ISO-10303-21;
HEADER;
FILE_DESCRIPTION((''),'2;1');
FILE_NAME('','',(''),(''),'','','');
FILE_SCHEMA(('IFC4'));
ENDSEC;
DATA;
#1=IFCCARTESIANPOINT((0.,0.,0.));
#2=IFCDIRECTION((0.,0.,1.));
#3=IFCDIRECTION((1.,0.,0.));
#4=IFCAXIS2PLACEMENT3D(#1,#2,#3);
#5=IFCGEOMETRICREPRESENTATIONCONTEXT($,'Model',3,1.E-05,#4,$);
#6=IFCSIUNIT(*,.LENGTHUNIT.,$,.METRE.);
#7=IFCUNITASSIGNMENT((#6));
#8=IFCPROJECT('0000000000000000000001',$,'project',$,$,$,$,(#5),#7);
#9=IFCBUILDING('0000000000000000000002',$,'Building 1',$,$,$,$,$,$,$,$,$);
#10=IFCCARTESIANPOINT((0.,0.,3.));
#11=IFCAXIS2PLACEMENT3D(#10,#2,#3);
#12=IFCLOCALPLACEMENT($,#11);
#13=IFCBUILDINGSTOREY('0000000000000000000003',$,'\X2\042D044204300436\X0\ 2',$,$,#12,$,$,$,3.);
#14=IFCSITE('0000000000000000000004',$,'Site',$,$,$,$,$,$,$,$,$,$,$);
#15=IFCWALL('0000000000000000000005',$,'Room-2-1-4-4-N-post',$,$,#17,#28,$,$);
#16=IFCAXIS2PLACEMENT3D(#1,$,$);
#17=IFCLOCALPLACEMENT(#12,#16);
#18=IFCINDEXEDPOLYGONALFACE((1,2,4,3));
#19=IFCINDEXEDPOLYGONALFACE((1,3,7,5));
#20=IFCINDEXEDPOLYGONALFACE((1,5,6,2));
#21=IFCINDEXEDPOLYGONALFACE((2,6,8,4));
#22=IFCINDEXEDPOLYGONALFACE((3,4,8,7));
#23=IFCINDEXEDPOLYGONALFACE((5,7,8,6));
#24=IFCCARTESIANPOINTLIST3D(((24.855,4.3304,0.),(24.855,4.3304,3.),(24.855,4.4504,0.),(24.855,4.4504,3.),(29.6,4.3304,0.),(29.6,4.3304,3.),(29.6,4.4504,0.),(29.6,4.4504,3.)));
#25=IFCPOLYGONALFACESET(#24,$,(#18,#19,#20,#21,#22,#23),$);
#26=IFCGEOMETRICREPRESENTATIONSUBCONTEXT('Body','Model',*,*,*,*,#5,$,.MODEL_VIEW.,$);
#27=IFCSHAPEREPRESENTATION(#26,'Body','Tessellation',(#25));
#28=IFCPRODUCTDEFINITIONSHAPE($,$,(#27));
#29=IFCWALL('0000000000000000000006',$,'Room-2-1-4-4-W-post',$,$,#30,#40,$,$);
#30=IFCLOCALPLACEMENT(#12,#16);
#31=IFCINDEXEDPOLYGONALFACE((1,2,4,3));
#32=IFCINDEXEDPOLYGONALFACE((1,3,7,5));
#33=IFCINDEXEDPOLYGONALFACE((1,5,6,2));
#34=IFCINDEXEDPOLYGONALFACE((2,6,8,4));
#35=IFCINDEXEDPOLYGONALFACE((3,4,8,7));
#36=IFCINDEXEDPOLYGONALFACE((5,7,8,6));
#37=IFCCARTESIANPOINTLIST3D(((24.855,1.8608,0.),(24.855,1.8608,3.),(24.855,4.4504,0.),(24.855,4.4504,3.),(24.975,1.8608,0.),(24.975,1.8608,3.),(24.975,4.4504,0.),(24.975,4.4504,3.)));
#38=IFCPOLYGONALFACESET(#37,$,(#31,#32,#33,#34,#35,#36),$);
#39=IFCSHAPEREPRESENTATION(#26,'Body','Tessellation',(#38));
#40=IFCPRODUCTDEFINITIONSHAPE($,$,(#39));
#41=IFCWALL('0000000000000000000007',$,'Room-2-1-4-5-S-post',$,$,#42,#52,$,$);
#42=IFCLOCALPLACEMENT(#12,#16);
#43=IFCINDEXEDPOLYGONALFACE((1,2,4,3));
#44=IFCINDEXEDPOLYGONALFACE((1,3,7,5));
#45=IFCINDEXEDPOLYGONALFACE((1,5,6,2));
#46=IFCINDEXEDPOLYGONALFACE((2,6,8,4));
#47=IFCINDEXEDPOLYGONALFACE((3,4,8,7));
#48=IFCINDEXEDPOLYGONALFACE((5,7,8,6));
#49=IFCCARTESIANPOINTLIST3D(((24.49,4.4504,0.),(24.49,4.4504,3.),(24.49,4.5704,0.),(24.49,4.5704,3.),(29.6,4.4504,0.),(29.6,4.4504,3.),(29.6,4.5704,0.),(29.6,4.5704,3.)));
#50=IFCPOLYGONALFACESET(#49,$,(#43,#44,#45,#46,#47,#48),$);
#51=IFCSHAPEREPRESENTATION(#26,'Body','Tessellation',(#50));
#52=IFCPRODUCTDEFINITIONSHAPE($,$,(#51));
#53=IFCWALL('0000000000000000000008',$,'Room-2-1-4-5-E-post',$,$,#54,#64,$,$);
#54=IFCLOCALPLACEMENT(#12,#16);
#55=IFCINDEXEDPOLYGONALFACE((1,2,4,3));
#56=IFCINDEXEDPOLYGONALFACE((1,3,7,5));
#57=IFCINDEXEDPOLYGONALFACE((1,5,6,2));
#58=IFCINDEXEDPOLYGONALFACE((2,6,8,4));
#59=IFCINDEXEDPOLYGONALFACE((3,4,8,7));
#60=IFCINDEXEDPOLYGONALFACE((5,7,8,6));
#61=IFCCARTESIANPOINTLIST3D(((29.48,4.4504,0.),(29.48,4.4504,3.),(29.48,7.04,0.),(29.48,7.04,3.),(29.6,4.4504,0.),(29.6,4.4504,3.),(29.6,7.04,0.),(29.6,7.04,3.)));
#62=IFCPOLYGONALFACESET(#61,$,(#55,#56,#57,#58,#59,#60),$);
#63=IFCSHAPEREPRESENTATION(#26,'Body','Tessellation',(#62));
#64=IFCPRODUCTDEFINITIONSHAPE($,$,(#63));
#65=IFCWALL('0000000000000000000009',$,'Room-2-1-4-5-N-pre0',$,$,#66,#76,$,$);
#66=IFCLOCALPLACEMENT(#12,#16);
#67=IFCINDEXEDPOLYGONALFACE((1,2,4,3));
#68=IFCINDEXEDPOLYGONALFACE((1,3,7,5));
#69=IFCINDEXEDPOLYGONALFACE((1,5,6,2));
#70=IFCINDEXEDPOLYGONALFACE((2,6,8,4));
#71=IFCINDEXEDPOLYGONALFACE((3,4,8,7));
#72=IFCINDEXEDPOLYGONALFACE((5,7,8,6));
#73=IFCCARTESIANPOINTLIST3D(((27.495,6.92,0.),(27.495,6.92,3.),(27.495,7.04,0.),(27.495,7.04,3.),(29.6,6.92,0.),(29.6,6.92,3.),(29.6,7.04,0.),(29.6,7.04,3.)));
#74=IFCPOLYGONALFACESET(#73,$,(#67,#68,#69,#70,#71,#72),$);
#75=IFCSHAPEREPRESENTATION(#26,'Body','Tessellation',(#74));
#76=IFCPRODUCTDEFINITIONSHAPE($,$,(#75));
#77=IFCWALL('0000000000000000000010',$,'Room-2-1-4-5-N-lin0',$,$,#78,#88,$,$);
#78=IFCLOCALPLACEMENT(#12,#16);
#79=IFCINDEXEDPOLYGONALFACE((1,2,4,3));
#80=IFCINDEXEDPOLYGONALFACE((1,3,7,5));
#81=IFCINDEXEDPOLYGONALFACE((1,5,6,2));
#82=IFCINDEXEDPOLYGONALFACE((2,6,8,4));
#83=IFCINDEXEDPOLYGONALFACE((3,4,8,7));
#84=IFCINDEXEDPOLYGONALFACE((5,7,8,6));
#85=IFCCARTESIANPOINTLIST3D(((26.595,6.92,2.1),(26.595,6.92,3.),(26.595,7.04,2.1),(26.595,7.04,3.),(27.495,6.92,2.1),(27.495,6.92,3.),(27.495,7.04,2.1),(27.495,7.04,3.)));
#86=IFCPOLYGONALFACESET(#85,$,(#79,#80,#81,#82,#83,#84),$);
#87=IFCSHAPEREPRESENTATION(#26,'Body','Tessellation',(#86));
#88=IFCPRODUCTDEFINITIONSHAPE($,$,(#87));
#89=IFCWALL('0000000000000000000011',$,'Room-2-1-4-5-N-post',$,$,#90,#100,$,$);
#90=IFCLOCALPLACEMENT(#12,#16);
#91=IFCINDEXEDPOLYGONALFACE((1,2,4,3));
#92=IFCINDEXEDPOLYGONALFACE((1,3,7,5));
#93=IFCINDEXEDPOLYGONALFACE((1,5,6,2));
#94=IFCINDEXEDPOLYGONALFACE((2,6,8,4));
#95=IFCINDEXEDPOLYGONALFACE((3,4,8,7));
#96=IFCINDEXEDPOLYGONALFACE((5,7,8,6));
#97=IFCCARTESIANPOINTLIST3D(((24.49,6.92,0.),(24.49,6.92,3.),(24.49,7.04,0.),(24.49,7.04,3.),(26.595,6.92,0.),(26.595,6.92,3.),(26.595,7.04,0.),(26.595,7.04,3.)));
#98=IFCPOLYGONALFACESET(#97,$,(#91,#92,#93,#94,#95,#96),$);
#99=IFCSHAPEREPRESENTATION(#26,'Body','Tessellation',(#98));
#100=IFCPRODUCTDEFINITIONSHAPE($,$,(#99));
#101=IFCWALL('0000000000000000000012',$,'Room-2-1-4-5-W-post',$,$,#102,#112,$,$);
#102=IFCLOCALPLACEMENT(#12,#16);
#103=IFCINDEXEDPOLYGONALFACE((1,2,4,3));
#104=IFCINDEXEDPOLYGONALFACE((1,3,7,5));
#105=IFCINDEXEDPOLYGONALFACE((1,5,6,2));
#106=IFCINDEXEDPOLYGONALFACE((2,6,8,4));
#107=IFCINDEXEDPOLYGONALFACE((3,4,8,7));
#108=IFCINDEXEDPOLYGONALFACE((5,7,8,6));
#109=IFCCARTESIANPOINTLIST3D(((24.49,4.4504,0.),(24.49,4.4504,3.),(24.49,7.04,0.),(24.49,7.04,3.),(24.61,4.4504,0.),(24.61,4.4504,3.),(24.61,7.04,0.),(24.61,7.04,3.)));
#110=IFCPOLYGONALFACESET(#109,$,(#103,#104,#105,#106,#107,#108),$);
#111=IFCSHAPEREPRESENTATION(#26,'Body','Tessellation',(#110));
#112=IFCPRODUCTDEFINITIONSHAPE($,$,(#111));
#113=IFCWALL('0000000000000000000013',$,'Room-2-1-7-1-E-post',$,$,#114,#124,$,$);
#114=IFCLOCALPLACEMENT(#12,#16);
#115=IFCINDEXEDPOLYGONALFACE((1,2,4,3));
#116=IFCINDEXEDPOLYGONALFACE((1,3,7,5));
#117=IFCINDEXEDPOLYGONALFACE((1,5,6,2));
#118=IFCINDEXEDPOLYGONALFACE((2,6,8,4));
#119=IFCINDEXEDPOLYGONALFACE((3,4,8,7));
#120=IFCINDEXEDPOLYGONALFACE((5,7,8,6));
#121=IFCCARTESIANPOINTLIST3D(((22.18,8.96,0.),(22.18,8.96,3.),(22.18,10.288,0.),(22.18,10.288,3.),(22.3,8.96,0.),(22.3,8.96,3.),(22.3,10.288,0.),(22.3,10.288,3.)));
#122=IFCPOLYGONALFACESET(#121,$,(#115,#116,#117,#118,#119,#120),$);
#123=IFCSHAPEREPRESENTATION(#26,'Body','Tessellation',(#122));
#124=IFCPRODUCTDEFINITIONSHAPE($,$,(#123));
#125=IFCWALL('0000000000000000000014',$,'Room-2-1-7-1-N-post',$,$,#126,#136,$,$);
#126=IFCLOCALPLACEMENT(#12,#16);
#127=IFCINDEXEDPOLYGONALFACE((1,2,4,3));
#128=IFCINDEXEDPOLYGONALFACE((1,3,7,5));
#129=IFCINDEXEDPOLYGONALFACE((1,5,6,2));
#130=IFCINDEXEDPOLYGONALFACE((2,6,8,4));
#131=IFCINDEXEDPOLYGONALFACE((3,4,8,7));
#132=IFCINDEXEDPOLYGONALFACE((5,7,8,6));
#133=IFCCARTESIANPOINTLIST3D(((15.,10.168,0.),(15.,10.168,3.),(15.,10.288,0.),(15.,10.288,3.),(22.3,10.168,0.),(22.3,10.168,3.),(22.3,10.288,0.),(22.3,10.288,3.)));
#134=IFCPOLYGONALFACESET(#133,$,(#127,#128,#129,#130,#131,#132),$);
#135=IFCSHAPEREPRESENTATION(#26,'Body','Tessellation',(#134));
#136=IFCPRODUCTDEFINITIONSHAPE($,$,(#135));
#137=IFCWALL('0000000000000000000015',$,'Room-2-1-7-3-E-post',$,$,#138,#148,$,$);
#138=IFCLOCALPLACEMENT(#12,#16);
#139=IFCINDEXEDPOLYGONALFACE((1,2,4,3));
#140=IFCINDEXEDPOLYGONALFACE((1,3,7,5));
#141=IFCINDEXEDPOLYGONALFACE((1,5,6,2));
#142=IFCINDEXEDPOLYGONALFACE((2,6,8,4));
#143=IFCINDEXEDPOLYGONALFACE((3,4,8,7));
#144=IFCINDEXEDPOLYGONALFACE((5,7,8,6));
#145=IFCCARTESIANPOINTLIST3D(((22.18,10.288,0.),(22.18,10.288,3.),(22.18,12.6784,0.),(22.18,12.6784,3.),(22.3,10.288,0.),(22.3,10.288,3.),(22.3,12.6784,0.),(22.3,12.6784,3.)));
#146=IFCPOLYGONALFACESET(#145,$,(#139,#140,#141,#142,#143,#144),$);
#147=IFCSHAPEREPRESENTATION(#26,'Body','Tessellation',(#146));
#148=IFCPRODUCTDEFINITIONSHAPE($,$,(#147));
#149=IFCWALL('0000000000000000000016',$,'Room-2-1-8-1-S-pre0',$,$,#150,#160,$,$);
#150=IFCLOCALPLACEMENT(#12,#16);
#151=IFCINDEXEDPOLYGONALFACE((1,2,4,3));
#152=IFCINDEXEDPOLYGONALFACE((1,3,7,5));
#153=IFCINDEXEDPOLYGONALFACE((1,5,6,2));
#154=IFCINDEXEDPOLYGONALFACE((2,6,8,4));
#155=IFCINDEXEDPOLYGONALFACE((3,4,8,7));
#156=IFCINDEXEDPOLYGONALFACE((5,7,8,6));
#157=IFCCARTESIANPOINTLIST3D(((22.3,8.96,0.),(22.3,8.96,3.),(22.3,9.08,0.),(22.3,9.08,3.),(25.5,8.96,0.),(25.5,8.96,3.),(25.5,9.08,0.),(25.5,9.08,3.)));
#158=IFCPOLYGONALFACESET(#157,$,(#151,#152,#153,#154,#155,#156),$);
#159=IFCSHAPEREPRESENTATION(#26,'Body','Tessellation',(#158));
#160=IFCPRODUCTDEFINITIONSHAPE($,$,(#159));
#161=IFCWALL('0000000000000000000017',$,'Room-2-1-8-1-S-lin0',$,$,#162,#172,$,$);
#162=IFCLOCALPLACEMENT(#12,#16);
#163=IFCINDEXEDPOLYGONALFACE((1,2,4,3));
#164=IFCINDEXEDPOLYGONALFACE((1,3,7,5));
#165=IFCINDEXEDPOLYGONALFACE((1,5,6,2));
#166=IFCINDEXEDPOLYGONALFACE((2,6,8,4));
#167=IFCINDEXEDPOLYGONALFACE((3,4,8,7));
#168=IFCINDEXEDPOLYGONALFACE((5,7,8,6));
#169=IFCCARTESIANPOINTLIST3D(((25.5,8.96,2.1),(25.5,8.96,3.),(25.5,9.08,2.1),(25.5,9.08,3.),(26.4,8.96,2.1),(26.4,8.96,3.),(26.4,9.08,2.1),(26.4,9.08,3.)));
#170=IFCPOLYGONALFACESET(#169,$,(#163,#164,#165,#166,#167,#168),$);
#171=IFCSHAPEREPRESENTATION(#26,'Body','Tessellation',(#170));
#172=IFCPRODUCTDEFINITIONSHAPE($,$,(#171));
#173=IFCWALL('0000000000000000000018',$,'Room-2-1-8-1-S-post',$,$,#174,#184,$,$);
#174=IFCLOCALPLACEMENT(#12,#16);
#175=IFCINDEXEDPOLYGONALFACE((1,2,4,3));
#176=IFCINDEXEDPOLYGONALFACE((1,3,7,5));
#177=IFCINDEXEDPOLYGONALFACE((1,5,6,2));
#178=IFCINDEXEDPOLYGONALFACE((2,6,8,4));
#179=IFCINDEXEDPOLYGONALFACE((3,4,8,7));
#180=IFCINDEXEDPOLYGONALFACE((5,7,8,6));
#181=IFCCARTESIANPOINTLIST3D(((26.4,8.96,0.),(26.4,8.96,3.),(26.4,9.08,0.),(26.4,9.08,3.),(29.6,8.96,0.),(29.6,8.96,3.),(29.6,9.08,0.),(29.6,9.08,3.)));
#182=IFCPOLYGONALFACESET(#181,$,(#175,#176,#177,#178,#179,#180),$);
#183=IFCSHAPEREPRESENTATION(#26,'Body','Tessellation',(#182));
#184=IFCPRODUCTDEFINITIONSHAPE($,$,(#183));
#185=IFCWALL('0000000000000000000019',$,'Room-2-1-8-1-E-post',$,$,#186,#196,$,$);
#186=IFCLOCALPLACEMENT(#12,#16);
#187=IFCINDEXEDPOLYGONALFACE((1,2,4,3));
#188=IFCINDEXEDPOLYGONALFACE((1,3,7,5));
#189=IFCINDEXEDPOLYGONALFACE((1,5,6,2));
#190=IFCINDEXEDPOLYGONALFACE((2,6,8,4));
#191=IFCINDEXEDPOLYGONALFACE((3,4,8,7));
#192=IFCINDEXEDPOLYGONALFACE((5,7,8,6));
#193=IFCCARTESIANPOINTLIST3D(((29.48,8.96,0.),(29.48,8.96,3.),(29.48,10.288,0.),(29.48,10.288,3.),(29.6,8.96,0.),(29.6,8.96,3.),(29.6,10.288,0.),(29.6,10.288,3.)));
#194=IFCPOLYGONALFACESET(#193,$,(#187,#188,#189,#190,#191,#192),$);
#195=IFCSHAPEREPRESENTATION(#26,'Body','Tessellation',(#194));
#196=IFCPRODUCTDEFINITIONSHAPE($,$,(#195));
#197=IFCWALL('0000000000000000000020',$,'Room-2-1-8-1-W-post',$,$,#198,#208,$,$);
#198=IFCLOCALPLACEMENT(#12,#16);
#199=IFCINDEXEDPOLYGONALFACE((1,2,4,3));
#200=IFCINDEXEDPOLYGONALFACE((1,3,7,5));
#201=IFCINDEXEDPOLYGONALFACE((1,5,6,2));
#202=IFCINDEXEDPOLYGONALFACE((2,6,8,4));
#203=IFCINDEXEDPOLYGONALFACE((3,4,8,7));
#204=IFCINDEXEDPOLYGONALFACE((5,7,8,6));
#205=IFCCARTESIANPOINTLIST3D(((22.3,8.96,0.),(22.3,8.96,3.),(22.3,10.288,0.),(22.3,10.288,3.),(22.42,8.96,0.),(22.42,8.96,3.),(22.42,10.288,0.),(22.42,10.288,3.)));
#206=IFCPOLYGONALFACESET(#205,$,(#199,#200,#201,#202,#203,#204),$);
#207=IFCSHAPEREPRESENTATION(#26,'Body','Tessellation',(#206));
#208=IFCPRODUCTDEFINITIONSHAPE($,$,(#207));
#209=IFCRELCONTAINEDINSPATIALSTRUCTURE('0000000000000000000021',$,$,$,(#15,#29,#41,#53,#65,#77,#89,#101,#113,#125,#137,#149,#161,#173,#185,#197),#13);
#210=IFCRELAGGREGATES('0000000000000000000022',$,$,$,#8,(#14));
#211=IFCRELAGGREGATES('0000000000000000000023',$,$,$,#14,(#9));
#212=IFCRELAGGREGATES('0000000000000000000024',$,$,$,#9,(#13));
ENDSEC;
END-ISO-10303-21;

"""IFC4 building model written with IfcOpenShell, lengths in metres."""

from ifc_helpers import new_model, si_unit, frame, origin_with_axes, place, context, subcontext, project, spatial, indexed_curve, outline, extrude, element, save


model = new_model("IFC4")

# Units and contexts
model_context = context("Model", 3, precision=1e-05, world=origin_with_axes())
body_context = subcontext(model_context, "Body", "Model", "MODEL_VIEW")
ifc_project = project(units=[si_unit("LENGTHUNIT", "METRE")], contexts=[model_context])

# Site, building, storey
site = spatial("IfcSite", under=ifc_project, Name="Site")
building = spatial("IfcBuilding", under=site, Name="Building 1")
storey_placement = place(None, frame((0.0, 0.0, 3.0), z_axis=(0.0, 0.0, 1.0), x_axis=(1.0, 0.0, 0.0)))
storey = spatial("IfcBuildingStorey", under=building, at=storey_placement, Name="Этаж 2", Elevation=3.0)

# Walls
wall_1_placement = place(storey_placement, frame((29.6, 4.4504, 0.0), z_axis=(0.0, 0.0, 1.0), x_axis=(-1.0, 0.0, 0.0)))
element("IfcWall", 1, at=wall_1_placement, inside=storey, Name="Room-2-1-4-4-N-post", context=body_context, shape_type="SweptSolid", body=[
    extrude(outline(indexed_curve([(0.0, 0.0), (0.0, 0.12), (4.745, 0.12), (4.745, 0.0), (0.0, 0.0)], self_intersect=False)), origin_with_axes(), (0.0, 0.0, 1.0), 3.0),
])
wall_2_placement = place(storey_placement, frame((24.855, 4.4504, 0.0), z_axis=(0.0, 0.0, 1.0), x_axis=(0.0, -1.0, 0.0)))
element("IfcWall", 2, at=wall_2_placement, inside=storey, Name="Room-2-1-4-4-W-post", context=body_context, shape_type="SweptSolid", body=[
    extrude(outline(indexed_curve([(0.0, 0.0), (0.0, 0.12), (2.5896, 0.12), (2.5896, 0.0), (0.0, 0.0)], self_intersect=False)), origin_with_axes(), (0.0, 0.0, 1.0), 3.0),
])
wall_3_placement = place(storey_placement, frame((24.49, 4.4504, 0.0), z_axis=(0.0, 0.0, 1.0), x_axis=(1.0, 0.0, 0.0)))
element("IfcWall", 3, at=wall_3_placement, inside=storey, Name="Room-2-1-4-5-S-post", context=body_context, shape_type="SweptSolid", body=[
    extrude(outline(indexed_curve([(0.0, 0.0), (0.0, 0.12), (5.11, 0.12), (5.11, 0.0), (0.0, 0.0)], self_intersect=False)), origin_with_axes(), (0.0, 0.0, 1.0), 3.0),
])
wall_4_placement = place(storey_placement, frame((29.6, 4.4504, 0.0), z_axis=(0.0, 0.0, 1.0), x_axis=(0.0, 1.0, 0.0)))
element("IfcWall", 4, at=wall_4_placement, inside=storey, Name="Room-2-1-4-5-E-post", context=body_context, shape_type="SweptSolid", body=[
    extrude(outline(indexed_curve([(0.0, 0.0), (0.0, 0.12), (2.5896, 0.12), (2.5896, 0.0), (0.0, 0.0)], self_intersect=False)), origin_with_axes(), (0.0, 0.0, 1.0), 3.0),
])
wall_5_placement = place(storey_placement, frame((29.6, 7.04, 0.0), z_axis=(0.0, 0.0, 1.0), x_axis=(-1.0, 0.0, 0.0)))
element("IfcWall", 5, at=wall_5_placement, inside=storey, Name="Room-2-1-4-5-N-pre0", context=body_context, shape_type="SweptSolid", body=[
    extrude(outline(indexed_curve([(0.0, 0.0), (0.0, 0.12), (2.105, 0.12), (2.105, 0.0), (0.0, 0.0)], self_intersect=False)), origin_with_axes(), (0.0, 0.0, 1.0), 3.0),
])
wall_6_placement = place(storey_placement, frame((27.495, 7.04, 2.1), z_axis=(0.0, 0.0, 1.0), x_axis=(-1.0, 0.0, 0.0)))
element("IfcWall", 6, at=wall_6_placement, inside=storey, Name="Room-2-1-4-5-N-lin0", context=body_context, shape_type="SweptSolid", body=[
    extrude(outline(indexed_curve([(0.0, 0.0), (0.0, 0.12), (0.9, 0.12), (0.9, 0.0), (0.0, 0.0)], self_intersect=False)), origin_with_axes(), (0.0, 0.0, 1.0), 0.9),
])
wall_7_placement = place(storey_placement, frame((26.595, 7.04, 0.0), z_axis=(0.0, 0.0, 1.0), x_axis=(-1.0, 0.0, 0.0)))
element("IfcWall", 7, at=wall_7_placement, inside=storey, Name="Room-2-1-4-5-N-post", context=body_context, shape_type="SweptSolid", body=[
    extrude(outline(indexed_curve([(0.0, 0.0), (0.0, 0.12), (2.105, 0.12), (2.105, 0.0), (0.0, 0.0)], self_intersect=False)), origin_with_axes(), (0.0, 0.0, 1.0), 3.0),
])
wall_8_placement = place(storey_placement, frame((24.49, 7.04, 0.0), z_axis=(0.0, 0.0, 1.0), x_axis=(0.0, -1.0, 0.0)))
element("IfcWall", 8, at=wall_8_placement, inside=storey, Name="Room-2-1-4-5-W-post", context=body_context, shape_type="SweptSolid", body=[
    extrude(outline(indexed_curve([(0.0, 0.0), (0.0, 0.12), (2.5896, 0.12), (2.5896, 0.0), (0.0, 0.0)], self_intersect=False)), origin_with_axes(), (0.0, 0.0, 1.0), 3.0),
])
wall_9_placement = place(storey_placement, frame((22.3, 8.96, 0.0), z_axis=(0.0, 0.0, 1.0), x_axis=(0.0, 1.0, 0.0)))
element("IfcWall", 9, at=wall_9_placement, inside=storey, Name="Room-2-1-7-1-E-post", context=body_context, shape_type="SweptSolid", body=[
    extrude(outline(indexed_curve([(0.0, 0.0), (0.0, 0.12), (1.328, 0.12), (1.328, 0.0), (0.0, 0.0)], self_intersect=False)), origin_with_axes(), (0.0, 0.0, 1.0), 3.0),
])
wall_10_placement = place(storey_placement, frame((22.3, 10.288, 0.0), z_axis=(0.0, 0.0, 1.0), x_axis=(-1.0, 0.0, 0.0)))
element("IfcWall", 10, at=wall_10_placement, inside=storey, Name="Room-2-1-7-1-N-post", context=body_context, shape_type="SweptSolid", body=[
    extrude(outline(indexed_curve([(0.0, 0.0), (0.0, 0.12), (7.3, 0.12), (7.3, 0.0), (0.0, 0.0)], self_intersect=False)), origin_with_axes(), (0.0, 0.0, 1.0), 3.0),
])
wall_11_placement = place(storey_placement, frame((22.3, 10.288, 0.0), z_axis=(0.0, 0.0, 1.0), x_axis=(0.0, 1.0, 0.0)))
element("IfcWall", 11, at=wall_11_placement, inside=storey, Name="Room-2-1-7-3-E-post", context=body_context, shape_type="SweptSolid", body=[
    extrude(outline(indexed_curve([(0.0, 0.0), (0.0, 0.12), (2.3904, 0.12), (2.3904, 0.0), (0.0, 0.0)], self_intersect=False)), origin_with_axes(), (0.0, 0.0, 1.0), 3.0),
])
wall_12_placement = place(storey_placement, frame((22.3, 8.96, 0.0), z_axis=(0.0, 0.0, 1.0), x_axis=(1.0, 0.0, 0.0)))
element("IfcWall", 12, at=wall_12_placement, inside=storey, Name="Room-2-1-8-1-S-pre0", context=body_context, shape_type="SweptSolid", body=[
    extrude(outline(indexed_curve([(0.0, 0.0), (0.0, 0.12), (3.2, 0.12), (3.2, 0.0), (0.0, 0.0)], self_intersect=False)), origin_with_axes(), (0.0, 0.0, 1.0), 3.0),
])
wall_13_placement = place(storey_placement, frame((25.5, 8.96, 2.1), z_axis=(0.0, 0.0, 1.0), x_axis=(1.0, 0.0, 0.0)))
element("IfcWall", 13, at=wall_13_placement, inside=storey, Name="Room-2-1-8-1-S-lin0", context=body_context, shape_type="SweptSolid", body=[
    extrude(outline(indexed_curve([(0.0, 0.0), (0.0, 0.12), (0.9, 0.12), (0.9, 0.0), (0.0, 0.0)], self_intersect=False)), origin_with_axes(), (0.0, 0.0, 1.0), 0.9),
])
wall_14_placement = place(storey_placement, frame((26.4, 8.96, 0.0), z_axis=(0.0, 0.0, 1.0), x_axis=(1.0, 0.0, 0.0)))
element("IfcWall", 14, at=wall_14_placement, inside=storey, Name="Room-2-1-8-1-S-post", context=body_context, shape_type="SweptSolid", body=[
    extrude(outline(indexed_curve([(0.0, 0.0), (0.0, 0.12), (3.2, 0.12), (3.2, 0.0), (0.0, 0.0)], self_intersect=False)), origin_with_axes(), (0.0, 0.0, 1.0), 3.0),
])
for number, where, z_axis, x_axis, name in (
    (15, (29.6, 8.96, 0.0), (0.0, 0.0, 1.0), (0.0, 1.0, 0.0), "Room-2-1-8-1-E-post"),
    (16, (22.3, 10.288, 0.0), (0.0, 0.0, 1.0), (0.0, -1.0, 0.0), "Room-2-1-8-1-W-post"),
):
    element("IfcWall", number, at=place(storey_placement, frame(where, z_axis=z_axis, x_axis=x_axis)), inside=storey, Name=name, context=body_context, shape_type="SweptSolid", body=[
        extrude(outline(indexed_curve([(0.0, 0.0), (0.0, 0.12), (1.328, 0.12), (1.328, 0.0), (0.0, 0.0)], self_intersect=False)), origin_with_axes(), (0.0, 0.0, 1.0), 3.0),
    ])

save(model, "model.ifc")
